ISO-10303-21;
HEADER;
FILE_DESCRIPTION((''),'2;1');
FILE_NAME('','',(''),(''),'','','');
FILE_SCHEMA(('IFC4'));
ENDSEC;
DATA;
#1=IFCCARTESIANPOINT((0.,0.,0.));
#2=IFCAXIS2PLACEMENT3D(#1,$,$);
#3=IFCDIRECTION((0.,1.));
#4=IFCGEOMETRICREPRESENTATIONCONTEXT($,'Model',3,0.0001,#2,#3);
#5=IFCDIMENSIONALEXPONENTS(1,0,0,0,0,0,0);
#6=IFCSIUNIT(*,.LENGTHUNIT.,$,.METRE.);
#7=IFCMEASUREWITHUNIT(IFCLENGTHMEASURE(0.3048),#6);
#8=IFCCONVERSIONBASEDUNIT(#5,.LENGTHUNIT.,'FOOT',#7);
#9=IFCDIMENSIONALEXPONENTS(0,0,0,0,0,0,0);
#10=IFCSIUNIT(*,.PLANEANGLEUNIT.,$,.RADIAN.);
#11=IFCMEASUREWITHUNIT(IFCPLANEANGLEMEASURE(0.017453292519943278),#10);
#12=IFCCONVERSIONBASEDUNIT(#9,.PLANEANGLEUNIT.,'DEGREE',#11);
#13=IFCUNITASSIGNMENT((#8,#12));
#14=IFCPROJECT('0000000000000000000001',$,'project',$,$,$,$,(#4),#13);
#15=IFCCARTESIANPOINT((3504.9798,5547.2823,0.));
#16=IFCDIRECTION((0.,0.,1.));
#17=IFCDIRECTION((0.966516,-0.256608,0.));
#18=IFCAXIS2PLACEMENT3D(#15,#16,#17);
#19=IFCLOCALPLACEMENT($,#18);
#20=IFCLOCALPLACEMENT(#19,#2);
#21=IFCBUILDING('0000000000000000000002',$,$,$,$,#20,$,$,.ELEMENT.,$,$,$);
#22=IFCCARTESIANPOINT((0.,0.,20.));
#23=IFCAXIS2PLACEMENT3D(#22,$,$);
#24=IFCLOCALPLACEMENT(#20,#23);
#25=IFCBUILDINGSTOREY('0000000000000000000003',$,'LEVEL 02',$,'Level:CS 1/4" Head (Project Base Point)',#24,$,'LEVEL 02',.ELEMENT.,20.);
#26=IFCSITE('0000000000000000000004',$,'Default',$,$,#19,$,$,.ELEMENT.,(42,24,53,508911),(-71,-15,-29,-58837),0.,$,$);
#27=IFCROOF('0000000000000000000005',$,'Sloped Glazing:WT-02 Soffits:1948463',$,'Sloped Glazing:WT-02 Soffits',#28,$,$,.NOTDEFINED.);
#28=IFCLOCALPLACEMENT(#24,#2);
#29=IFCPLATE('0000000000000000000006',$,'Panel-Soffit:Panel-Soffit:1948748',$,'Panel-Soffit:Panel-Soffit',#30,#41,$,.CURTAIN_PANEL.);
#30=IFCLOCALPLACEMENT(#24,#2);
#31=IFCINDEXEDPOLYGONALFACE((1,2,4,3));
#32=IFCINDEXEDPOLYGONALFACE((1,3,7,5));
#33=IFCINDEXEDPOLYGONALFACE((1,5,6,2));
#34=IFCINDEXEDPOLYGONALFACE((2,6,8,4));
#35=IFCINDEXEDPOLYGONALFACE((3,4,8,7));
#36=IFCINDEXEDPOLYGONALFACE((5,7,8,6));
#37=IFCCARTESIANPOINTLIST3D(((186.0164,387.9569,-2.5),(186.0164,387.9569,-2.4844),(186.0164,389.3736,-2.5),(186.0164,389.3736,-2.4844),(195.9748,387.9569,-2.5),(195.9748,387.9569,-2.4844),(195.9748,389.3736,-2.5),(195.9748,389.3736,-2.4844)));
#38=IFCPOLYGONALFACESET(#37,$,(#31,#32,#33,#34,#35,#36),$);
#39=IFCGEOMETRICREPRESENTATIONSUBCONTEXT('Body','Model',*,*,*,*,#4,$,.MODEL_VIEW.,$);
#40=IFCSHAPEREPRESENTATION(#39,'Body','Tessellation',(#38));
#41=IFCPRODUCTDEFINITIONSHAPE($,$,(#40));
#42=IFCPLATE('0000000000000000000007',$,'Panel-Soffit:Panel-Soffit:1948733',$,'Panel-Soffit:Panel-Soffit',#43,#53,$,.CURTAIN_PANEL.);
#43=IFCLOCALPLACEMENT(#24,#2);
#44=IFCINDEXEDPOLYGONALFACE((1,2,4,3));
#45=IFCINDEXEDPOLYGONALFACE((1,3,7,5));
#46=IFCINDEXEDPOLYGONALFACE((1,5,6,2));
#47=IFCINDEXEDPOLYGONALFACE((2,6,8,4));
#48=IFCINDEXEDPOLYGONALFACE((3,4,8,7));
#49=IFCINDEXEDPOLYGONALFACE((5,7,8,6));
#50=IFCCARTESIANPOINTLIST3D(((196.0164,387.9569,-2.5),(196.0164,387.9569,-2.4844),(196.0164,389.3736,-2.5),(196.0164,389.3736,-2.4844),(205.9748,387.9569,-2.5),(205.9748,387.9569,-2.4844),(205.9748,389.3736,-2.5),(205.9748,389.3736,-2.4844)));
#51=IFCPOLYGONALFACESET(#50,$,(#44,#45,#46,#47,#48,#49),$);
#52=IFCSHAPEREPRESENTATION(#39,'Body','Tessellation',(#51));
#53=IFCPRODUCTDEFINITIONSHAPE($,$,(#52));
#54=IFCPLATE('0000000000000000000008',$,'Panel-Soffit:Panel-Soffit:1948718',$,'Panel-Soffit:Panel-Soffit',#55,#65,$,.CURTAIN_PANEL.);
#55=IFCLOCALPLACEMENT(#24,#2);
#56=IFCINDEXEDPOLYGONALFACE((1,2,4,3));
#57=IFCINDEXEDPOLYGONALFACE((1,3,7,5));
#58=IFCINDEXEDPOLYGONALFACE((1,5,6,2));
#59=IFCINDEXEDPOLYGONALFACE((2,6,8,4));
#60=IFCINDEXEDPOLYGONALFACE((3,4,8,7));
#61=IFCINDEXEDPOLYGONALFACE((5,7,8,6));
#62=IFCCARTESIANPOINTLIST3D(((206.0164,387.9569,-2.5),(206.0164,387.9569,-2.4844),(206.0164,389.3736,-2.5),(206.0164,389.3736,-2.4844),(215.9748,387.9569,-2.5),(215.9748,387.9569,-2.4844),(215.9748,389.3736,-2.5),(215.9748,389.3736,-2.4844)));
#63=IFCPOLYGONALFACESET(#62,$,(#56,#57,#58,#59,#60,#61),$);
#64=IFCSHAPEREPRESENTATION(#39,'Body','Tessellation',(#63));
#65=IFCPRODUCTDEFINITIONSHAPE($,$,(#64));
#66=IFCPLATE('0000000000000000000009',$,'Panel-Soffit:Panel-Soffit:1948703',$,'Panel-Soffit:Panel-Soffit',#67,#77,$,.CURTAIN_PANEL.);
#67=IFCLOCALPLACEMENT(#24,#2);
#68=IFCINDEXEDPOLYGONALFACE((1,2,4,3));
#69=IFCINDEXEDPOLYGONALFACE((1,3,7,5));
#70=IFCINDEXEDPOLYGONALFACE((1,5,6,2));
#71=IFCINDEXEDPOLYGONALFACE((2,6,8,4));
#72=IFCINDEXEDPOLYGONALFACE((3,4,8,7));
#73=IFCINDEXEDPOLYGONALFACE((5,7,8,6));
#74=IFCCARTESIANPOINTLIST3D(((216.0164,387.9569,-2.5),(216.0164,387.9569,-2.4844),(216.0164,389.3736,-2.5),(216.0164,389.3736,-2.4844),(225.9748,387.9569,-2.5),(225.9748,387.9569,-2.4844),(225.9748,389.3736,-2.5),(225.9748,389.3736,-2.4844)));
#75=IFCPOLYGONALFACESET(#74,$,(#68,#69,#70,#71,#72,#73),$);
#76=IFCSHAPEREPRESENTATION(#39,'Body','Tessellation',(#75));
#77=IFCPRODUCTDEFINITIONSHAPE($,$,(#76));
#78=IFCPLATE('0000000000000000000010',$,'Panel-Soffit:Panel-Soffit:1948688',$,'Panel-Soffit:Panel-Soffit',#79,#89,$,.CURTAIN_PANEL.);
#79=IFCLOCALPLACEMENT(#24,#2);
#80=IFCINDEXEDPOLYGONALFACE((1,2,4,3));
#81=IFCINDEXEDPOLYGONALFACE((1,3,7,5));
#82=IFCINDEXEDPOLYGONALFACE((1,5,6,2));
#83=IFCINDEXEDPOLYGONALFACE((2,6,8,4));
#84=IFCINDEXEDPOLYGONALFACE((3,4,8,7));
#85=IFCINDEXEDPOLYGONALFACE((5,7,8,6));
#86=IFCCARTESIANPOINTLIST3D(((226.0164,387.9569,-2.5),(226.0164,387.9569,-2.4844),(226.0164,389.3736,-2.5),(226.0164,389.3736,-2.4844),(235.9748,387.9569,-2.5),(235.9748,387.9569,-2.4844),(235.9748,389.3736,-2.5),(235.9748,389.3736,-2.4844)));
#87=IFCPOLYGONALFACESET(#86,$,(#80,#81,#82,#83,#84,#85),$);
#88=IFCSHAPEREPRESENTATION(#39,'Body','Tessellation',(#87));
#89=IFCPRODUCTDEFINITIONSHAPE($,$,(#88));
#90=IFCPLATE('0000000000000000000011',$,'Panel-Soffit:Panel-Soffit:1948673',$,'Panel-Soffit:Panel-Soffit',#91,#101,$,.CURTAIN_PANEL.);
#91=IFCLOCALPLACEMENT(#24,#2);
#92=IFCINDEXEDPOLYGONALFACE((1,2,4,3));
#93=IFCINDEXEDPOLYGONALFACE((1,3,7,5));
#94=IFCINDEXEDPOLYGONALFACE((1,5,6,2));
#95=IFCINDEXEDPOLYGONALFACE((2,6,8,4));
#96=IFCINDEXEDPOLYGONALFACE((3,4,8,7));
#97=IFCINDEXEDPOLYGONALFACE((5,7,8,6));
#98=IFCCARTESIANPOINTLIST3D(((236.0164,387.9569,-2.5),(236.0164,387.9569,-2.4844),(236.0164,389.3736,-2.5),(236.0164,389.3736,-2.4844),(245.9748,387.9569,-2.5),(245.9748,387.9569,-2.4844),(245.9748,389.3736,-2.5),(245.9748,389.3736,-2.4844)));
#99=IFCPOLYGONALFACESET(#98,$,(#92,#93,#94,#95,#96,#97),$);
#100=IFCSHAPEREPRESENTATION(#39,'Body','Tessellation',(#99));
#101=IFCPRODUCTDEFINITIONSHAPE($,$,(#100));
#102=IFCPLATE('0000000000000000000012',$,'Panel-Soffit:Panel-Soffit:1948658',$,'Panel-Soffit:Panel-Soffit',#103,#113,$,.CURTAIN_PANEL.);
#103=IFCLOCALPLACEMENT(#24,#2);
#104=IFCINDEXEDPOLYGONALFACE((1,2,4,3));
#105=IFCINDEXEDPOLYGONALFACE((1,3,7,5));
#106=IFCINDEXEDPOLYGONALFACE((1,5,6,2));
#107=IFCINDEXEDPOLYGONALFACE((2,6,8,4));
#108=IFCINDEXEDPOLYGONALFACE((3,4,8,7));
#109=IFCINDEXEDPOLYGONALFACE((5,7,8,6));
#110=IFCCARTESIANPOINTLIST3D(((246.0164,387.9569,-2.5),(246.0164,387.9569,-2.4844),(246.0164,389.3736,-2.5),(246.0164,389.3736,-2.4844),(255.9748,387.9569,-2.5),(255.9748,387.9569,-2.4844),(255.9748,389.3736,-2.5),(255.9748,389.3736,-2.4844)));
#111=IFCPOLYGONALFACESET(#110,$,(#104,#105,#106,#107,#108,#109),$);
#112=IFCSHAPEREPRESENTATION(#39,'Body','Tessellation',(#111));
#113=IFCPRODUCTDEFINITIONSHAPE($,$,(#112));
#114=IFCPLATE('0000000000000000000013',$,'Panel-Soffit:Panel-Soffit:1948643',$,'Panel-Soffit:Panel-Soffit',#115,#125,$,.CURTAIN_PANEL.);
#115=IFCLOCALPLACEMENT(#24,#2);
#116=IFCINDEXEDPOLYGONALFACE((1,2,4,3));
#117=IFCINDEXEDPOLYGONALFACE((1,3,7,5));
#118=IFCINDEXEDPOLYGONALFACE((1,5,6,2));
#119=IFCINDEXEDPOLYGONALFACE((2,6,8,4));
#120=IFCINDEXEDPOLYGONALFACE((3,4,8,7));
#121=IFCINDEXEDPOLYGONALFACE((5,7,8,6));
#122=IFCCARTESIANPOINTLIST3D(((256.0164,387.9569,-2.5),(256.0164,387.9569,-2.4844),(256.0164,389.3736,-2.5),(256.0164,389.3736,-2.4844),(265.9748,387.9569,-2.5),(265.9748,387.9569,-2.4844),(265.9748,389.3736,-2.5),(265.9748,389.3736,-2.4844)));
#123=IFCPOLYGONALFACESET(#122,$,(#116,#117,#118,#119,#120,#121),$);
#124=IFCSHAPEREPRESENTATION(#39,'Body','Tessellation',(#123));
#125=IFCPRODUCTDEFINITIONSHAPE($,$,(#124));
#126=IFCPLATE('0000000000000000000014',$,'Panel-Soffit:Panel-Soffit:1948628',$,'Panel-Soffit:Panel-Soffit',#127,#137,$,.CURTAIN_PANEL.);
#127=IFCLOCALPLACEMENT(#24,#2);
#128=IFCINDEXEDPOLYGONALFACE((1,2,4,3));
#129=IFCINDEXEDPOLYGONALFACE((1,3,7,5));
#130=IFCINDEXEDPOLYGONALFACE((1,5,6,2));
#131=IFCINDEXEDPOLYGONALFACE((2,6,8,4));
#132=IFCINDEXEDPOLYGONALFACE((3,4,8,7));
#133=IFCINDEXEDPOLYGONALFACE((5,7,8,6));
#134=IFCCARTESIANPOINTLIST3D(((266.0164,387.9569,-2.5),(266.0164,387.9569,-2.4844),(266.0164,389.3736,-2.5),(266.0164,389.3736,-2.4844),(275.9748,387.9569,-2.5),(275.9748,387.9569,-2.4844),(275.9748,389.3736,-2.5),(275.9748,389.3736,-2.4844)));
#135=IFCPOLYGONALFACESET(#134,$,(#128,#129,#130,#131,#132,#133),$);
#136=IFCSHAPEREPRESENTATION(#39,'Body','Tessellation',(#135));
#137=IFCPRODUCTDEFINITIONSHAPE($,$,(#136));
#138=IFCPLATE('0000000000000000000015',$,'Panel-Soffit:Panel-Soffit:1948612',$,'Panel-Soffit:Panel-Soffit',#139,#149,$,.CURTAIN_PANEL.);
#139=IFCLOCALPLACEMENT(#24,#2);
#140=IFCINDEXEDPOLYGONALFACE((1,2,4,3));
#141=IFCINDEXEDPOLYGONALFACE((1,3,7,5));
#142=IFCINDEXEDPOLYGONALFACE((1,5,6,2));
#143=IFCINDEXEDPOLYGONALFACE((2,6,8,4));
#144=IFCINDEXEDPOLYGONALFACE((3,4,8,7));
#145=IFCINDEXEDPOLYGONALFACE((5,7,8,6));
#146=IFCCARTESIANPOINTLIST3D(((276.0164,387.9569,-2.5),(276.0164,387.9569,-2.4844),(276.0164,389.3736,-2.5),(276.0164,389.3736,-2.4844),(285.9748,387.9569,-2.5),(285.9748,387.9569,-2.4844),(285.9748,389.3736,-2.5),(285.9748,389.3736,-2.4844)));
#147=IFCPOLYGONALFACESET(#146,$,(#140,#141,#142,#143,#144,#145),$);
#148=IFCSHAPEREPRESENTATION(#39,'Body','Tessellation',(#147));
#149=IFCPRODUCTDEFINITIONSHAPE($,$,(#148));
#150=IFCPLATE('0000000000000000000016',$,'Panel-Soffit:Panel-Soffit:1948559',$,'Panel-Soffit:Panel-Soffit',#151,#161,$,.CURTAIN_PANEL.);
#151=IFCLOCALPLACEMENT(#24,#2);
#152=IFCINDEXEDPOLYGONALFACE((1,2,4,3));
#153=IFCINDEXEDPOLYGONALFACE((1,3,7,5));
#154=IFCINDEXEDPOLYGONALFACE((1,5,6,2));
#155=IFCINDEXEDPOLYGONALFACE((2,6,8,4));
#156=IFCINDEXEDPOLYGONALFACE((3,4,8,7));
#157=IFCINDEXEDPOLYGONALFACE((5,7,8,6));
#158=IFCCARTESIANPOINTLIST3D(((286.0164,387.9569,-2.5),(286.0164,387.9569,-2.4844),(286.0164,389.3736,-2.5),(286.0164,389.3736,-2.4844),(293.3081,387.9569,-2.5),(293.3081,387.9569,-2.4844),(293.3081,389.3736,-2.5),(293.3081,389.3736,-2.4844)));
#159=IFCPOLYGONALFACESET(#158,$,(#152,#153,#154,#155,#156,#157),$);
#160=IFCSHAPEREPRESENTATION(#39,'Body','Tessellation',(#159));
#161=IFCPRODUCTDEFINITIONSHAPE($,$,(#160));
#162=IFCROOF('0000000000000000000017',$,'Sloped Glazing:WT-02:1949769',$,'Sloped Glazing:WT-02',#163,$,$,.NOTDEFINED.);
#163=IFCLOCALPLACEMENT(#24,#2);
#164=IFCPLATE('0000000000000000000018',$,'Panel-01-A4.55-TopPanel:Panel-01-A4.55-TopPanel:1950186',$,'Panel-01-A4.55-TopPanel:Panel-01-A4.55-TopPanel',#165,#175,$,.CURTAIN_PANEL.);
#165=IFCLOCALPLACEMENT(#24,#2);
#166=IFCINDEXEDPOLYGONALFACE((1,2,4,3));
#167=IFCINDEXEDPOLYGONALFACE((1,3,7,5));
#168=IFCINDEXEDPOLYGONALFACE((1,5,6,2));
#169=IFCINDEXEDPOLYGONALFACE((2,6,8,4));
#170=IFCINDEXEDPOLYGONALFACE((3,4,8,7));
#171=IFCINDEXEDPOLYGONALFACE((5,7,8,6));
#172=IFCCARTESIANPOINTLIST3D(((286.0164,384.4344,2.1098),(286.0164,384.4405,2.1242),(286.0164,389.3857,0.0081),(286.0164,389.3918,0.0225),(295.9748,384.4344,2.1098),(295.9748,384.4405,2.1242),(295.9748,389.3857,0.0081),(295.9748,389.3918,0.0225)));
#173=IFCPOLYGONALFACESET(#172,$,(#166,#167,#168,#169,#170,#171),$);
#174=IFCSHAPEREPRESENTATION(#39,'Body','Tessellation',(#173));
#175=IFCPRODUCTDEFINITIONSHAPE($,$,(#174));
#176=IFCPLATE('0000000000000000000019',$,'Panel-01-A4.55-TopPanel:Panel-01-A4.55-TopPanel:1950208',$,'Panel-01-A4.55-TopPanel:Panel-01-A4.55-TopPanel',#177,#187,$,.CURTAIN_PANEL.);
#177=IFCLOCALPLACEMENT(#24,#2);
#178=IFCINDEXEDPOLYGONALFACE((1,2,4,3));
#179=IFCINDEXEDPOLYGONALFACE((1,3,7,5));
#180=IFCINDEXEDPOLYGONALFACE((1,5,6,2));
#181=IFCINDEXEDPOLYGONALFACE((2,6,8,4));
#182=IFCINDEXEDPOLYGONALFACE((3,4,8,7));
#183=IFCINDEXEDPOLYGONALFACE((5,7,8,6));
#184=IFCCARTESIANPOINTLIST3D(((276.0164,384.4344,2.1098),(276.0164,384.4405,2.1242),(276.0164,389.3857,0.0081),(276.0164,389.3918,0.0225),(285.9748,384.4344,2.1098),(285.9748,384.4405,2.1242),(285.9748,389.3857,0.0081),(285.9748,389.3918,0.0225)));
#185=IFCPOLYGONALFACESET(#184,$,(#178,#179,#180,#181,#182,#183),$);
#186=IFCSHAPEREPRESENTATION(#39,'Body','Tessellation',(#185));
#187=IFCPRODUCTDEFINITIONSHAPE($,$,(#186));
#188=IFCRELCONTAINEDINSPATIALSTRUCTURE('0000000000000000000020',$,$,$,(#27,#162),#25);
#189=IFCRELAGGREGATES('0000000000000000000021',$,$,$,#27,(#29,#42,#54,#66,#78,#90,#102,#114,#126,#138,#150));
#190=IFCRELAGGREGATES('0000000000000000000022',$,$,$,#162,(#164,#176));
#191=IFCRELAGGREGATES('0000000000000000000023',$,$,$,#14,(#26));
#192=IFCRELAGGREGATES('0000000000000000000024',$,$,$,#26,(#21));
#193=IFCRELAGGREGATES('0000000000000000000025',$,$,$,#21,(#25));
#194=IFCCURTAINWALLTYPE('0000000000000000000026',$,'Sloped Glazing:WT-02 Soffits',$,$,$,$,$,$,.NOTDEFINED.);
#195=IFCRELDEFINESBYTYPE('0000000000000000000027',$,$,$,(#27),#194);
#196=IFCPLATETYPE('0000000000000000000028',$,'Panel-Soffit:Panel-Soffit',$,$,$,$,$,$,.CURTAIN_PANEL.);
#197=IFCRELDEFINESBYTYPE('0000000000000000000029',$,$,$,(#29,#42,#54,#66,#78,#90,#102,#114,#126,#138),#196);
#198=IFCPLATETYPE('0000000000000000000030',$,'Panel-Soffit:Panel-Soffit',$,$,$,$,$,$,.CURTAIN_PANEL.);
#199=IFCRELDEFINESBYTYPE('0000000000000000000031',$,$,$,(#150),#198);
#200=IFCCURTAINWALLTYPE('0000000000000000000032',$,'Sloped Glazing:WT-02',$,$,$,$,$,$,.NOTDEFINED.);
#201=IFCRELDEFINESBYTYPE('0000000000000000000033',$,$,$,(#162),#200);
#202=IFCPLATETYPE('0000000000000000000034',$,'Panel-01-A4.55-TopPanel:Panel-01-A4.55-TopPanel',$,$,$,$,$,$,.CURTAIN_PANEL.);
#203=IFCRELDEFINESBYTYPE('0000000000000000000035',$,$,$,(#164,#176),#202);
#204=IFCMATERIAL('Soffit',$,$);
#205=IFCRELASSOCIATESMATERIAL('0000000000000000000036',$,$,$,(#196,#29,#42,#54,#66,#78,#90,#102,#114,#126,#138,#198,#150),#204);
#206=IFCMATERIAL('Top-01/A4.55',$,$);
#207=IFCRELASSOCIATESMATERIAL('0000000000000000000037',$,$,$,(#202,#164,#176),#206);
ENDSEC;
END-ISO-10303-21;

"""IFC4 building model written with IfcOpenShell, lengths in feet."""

from ifc_helpers import new_model, entity, si_unit, converted_unit, direction, frame, origin, place, context, subcontext, project, spatial, indexed_curve, outline, extrude, source, transform, mapped, material, type_object, type_shapes, element, aggregate, save


model = new_model("IFC4")

# Units and contexts
model_context = context("Model", 3, precision=0.0001, world=origin(), true_north=direction((0.0, 1.0)))
body_context = subcontext(model_context, "Body", "Model", "MODEL_VIEW")
ifc_project = project(units=[converted_unit("LENGTHUNIT", "FOOT", entity("IfcLengthMeasure", 0.3048), si_unit("LENGTHUNIT", "METRE"), dimensions=[1, 0, 0, 0, 0, 0, 0]), converted_unit("PLANEANGLEUNIT", "DEGREE", entity("IfcPlaneAngleMeasure", 0.017453292519943278), si_unit("PLANEANGLEUNIT", "RADIAN"), dimensions=[0, 0, 0, 0, 0, 0, 0])], contexts=[model_context])

# Site, building, storey
site_placement = place(None, frame((3504.9798, 5547.2823, 0.0), z_axis=(0.0, 0.0, 1.0), x_axis=(0.966516, -0.256608, 0.0)))
site = spatial("IfcSite", under=ifc_project, at=site_placement, Name="Default", CompositionType="ELEMENT", RefLatitude=(42, 24, 53, 508911), RefLongitude=(-71, -15, -29, -58837), RefElevation=0.0)
building_placement = place(site_placement, origin())
building = spatial("IfcBuilding", under=site, at=building_placement, CompositionType="ELEMENT")
storey_placement = place(building_placement, frame((0.0, 0.0, 20.0)))
storey = spatial("IfcBuildingStorey", under=building, at=storey_placement, Name="LEVEL 02", ObjectType="Level:CS 1/4\" Head (Project Base Point)", LongName="LEVEL 02", CompositionType="ELEMENT", Elevation=20.0)

# Roofs, plates
curtain_wall_type_1 = type_object("IfcCurtainWallType", Name="Sloped Glazing:WT-02 Soffits", PredefinedType="NOTDEFINED")
roof_1_placement = place(storey_placement, frame((0.0, 0.0, -20.0)))
roof_1 = element("IfcRoof", 1, at=roof_1_placement, inside=storey, type_object=curtain_wall_type_1, Name="Sloped Glazing:WT-02 Soffits:1948463", ObjectType="Sloped Glazing:WT-02 Soffits", PredefinedType="NOTDEFINED")
ifc_material_1 = material(Name="Soffit")
plate_type_1 = type_object("IfcPlateType", Name="Panel-Soffit:Panel-Soffit", PredefinedType="CURTAIN_PANEL", material=ifc_material_1)
shared_shape_1 = source(origin(), body_context, "Body", "SweptSolid", [
    extrude(outline(indexed_curve([(-0.0078, -4.9792), (0.0078, -4.9792), (0.0078, 4.9792), (-0.0078, 4.9792), (-0.0078, -4.9792)], self_intersect=False)), frame((0.0, -0.0078, 0.0208), z_axis=(0.0, 0.0, 1.0), x_axis=(0.0, -1.0, 0.0)), (0.0, 0.0, 1.0), 1.4167),
])
type_shapes(plate_type_1, [shared_shape_1])
plate_1_placement = place(roof_1_placement, frame((190.9956, 387.9361, 17.5), z_axis=(0.0, 1.0, 0.0), x_axis=(1.0, 0.0, 0.0)))
plate_1 = element("IfcPlate", 2, at=plate_1_placement, type_object=plate_type_1, material=ifc_material_1, Name="Panel-Soffit:Panel-Soffit:1948748", ObjectType="Panel-Soffit:Panel-Soffit", PredefinedType="CURTAIN_PANEL", context=body_context, shape_type="MappedRepresentation", body=[
    mapped(shared_shape_1, transform((0.0, 0.0, 0.0), scale=1.0)),
])
plate_2_placement = place(roof_1_placement, frame((200.9956, 387.9361, 17.5), z_axis=(0.0, 1.0, 0.0), x_axis=(1.0, 0.0, 0.0)))
plate_2 = element("IfcPlate", 3, at=plate_2_placement, type_object=plate_type_1, material=ifc_material_1, Name="Panel-Soffit:Panel-Soffit:1948733", ObjectType="Panel-Soffit:Panel-Soffit", PredefinedType="CURTAIN_PANEL", context=body_context, shape_type="MappedRepresentation", body=[
    mapped(shared_shape_1, transform((0.0, 0.0, 0.0), scale=1.0)),
])
plate_3_placement = place(roof_1_placement, frame((210.9956, 387.9361, 17.5), z_axis=(0.0, 1.0, 0.0), x_axis=(1.0, 0.0, 0.0)))
plate_3 = element("IfcPlate", 4, at=plate_3_placement, type_object=plate_type_1, material=ifc_material_1, Name="Panel-Soffit:Panel-Soffit:1948718", ObjectType="Panel-Soffit:Panel-Soffit", PredefinedType="CURTAIN_PANEL", context=body_context, shape_type="MappedRepresentation", body=[
    mapped(shared_shape_1, transform((0.0, 0.0, 0.0), scale=1.0)),
])
plate_4_placement = place(roof_1_placement, frame((220.9956, 387.9361, 17.5), z_axis=(0.0, 1.0, 0.0), x_axis=(1.0, 0.0, 0.0)))
plate_4 = element("IfcPlate", 5, at=plate_4_placement, type_object=plate_type_1, material=ifc_material_1, Name="Panel-Soffit:Panel-Soffit:1948703", ObjectType="Panel-Soffit:Panel-Soffit", PredefinedType="CURTAIN_PANEL", context=body_context, shape_type="MappedRepresentation", body=[
    mapped(shared_shape_1, transform((0.0, 0.0, 0.0), scale=1.0)),
])
plate_5_placement = place(roof_1_placement, frame((230.9956, 387.9361, 17.5), z_axis=(0.0, 1.0, 0.0), x_axis=(1.0, 0.0, 0.0)))
plate_5 = element("IfcPlate", 6, at=plate_5_placement, type_object=plate_type_1, material=ifc_material_1, Name="Panel-Soffit:Panel-Soffit:1948688", ObjectType="Panel-Soffit:Panel-Soffit", PredefinedType="CURTAIN_PANEL", context=body_context, shape_type="MappedRepresentation", body=[
    mapped(shared_shape_1, transform((0.0, 0.0, 0.0), scale=1.0)),
])
plate_6_placement = place(roof_1_placement, frame((240.9956, 387.9361, 17.5), z_axis=(0.0, 1.0, 0.0), x_axis=(1.0, 0.0, 0.0)))
plate_6 = element("IfcPlate", 7, at=plate_6_placement, type_object=plate_type_1, material=ifc_material_1, Name="Panel-Soffit:Panel-Soffit:1948673", ObjectType="Panel-Soffit:Panel-Soffit", PredefinedType="CURTAIN_PANEL", context=body_context, shape_type="MappedRepresentation", body=[
    mapped(shared_shape_1, transform((0.0, 0.0, 0.0), scale=1.0)),
])
plate_7_placement = place(roof_1_placement, frame((250.9956, 387.9361, 17.5), z_axis=(0.0, 1.0, 0.0), x_axis=(1.0, 0.0, 0.0)))
plate_7 = element("IfcPlate", 8, at=plate_7_placement, type_object=plate_type_1, material=ifc_material_1, Name="Panel-Soffit:Panel-Soffit:1948658", ObjectType="Panel-Soffit:Panel-Soffit", PredefinedType="CURTAIN_PANEL", context=body_context, shape_type="MappedRepresentation", body=[
    mapped(shared_shape_1, transform((0.0, 0.0, 0.0), scale=1.0)),
])
plate_8_placement = place(roof_1_placement, frame((260.9956, 387.9361, 17.5), z_axis=(0.0, 1.0, 0.0), x_axis=(1.0, 0.0, 0.0)))
plate_8 = element("IfcPlate", 9, at=plate_8_placement, type_object=plate_type_1, material=ifc_material_1, Name="Panel-Soffit:Panel-Soffit:1948643", ObjectType="Panel-Soffit:Panel-Soffit", PredefinedType="CURTAIN_PANEL", context=body_context, shape_type="MappedRepresentation", body=[
    mapped(shared_shape_1, transform((0.0, 0.0, 0.0), scale=1.0)),
])
plate_9_placement = place(roof_1_placement, frame((270.9956, 387.9361, 17.5), z_axis=(0.0, 1.0, 0.0), x_axis=(1.0, 0.0, 0.0)))
plate_9 = element("IfcPlate", 10, at=plate_9_placement, type_object=plate_type_1, material=ifc_material_1, Name="Panel-Soffit:Panel-Soffit:1948628", ObjectType="Panel-Soffit:Panel-Soffit", PredefinedType="CURTAIN_PANEL", context=body_context, shape_type="MappedRepresentation", body=[
    mapped(shared_shape_1, transform((0.0, 0.0, 0.0), scale=1.0)),
])
plate_10_placement = place(roof_1_placement, frame((280.9956, 387.9361, 17.5), z_axis=(0.0, 1.0, 0.0), x_axis=(1.0, 0.0, 0.0)))
plate_10 = element("IfcPlate", 11, at=plate_10_placement, type_object=plate_type_1, material=ifc_material_1, Name="Panel-Soffit:Panel-Soffit:1948612", ObjectType="Panel-Soffit:Panel-Soffit", PredefinedType="CURTAIN_PANEL", context=body_context, shape_type="MappedRepresentation", body=[
    mapped(shared_shape_1, transform((0.0, 0.0, 0.0), scale=1.0)),
])
plate_type_2 = type_object("IfcPlateType", Name="Panel-Soffit:Panel-Soffit", PredefinedType="CURTAIN_PANEL", material=ifc_material_1)
shared_shape_2 = source(origin(), body_context, "Body", "SweptSolid", [
    extrude(outline(indexed_curve([(-0.0078, -3.6458), (0.0078, -3.6458), (0.0078, 3.6458), (-0.0078, 3.6458), (-0.0078, -3.6458)], self_intersect=False)), frame((0.0, -0.0078, 0.0208), z_axis=(0.0, 0.0, 1.0), x_axis=(0.0, -1.0, 0.0)), (0.0, 0.0, 1.0), 1.4167),
])
type_shapes(plate_type_2, [shared_shape_2])
plate_11_placement = place(roof_1_placement, frame((289.6623, 387.9361, 17.5), z_axis=(0.0, 1.0, 0.0), x_axis=(1.0, 0.0, 0.0)))
plate_11 = element("IfcPlate", 12, at=plate_11_placement, type_object=plate_type_2, material=ifc_material_1, Name="Panel-Soffit:Panel-Soffit:1948559", ObjectType="Panel-Soffit:Panel-Soffit", PredefinedType="CURTAIN_PANEL", context=body_context, shape_type="MappedRepresentation", body=[
    mapped(shared_shape_2, transform((0.0, 0.0, 0.0), scale=1.0)),
])
aggregate(roof_1, [plate_1, plate_2, plate_3, plate_4, plate_5, plate_6, plate_7, plate_8, plate_9, plate_10, plate_11])
curtain_wall_type_2 = type_object("IfcCurtainWallType", Name="Sloped Glazing:WT-02", PredefinedType="NOTDEFINED")
roof_2_placement = place(storey_placement, frame((0.0, 0.0, -20.0)))
roof_2 = element("IfcRoof", 13, at=roof_2_placement, inside=storey, type_object=curtain_wall_type_2, Name="Sloped Glazing:WT-02:1949769", ObjectType="Sloped Glazing:WT-02", PredefinedType="NOTDEFINED")
ifc_material_2 = material(Name="Top-01/A4.55")
plate_type_3 = type_object("IfcPlateType", Name="Panel-01-A4.55-TopPanel:Panel-01-A4.55-TopPanel", PredefinedType="CURTAIN_PANEL", material=ifc_material_2)
shared_shape_3 = source(origin(), body_context, "Body", "SweptSolid", [
    extrude(outline(indexed_curve([(-0.0078, -4.9792), (0.0078, -4.9792), (0.0078, 4.9792), (-0.0078, 4.9792), (-0.0078, -4.9792)], self_intersect=False)), frame((0.0, -0.0078, 0.0208), z_axis=(0.0, 0.0, 1.0), x_axis=(0.0, -1.0, 0.0)), (0.0, 0.0, 1.0), 5.3788),
])
type_shapes(plate_type_3, [shared_shape_3])
plate_12_placement = place(roof_2_placement, frame((290.9956, 389.4048, 20.0), z_axis=(0.0, -0.920505, 0.390731), x_axis=(-1.0, 0.0, 0.0)))
plate_12 = element("IfcPlate", 14, at=plate_12_placement, type_object=plate_type_3, material=ifc_material_2, Name="Panel-01-A4.55-TopPanel:Panel-01-A4.55-TopPanel:1950186", ObjectType="Panel-01-A4.55-TopPanel:Panel-01-A4.55-TopPanel", PredefinedType="CURTAIN_PANEL", context=body_context, shape_type="MappedRepresentation", body=[
    mapped(shared_shape_3, transform((0.0, 0.0, 0.0), scale=1.0)),
])
plate_13_placement = place(roof_2_placement, frame((280.9956, 389.4048, 20.0), z_axis=(0.0, -0.920505, 0.390731), x_axis=(-1.0, 0.0, 0.0)))
plate_13 = element("IfcPlate", 15, at=plate_13_placement, type_object=plate_type_3, material=ifc_material_2, Name="Panel-01-A4.55-TopPanel:Panel-01-A4.55-TopPanel:1950208", ObjectType="Panel-01-A4.55-TopPanel:Panel-01-A4.55-TopPanel", PredefinedType="CURTAIN_PANEL", context=body_context, shape_type="MappedRepresentation", body=[
    mapped(shared_shape_3, transform((0.0, 0.0, 0.0), scale=1.0)),
])
aggregate(roof_2, [plate_12, plate_13])

save(model, "model.ifc")
